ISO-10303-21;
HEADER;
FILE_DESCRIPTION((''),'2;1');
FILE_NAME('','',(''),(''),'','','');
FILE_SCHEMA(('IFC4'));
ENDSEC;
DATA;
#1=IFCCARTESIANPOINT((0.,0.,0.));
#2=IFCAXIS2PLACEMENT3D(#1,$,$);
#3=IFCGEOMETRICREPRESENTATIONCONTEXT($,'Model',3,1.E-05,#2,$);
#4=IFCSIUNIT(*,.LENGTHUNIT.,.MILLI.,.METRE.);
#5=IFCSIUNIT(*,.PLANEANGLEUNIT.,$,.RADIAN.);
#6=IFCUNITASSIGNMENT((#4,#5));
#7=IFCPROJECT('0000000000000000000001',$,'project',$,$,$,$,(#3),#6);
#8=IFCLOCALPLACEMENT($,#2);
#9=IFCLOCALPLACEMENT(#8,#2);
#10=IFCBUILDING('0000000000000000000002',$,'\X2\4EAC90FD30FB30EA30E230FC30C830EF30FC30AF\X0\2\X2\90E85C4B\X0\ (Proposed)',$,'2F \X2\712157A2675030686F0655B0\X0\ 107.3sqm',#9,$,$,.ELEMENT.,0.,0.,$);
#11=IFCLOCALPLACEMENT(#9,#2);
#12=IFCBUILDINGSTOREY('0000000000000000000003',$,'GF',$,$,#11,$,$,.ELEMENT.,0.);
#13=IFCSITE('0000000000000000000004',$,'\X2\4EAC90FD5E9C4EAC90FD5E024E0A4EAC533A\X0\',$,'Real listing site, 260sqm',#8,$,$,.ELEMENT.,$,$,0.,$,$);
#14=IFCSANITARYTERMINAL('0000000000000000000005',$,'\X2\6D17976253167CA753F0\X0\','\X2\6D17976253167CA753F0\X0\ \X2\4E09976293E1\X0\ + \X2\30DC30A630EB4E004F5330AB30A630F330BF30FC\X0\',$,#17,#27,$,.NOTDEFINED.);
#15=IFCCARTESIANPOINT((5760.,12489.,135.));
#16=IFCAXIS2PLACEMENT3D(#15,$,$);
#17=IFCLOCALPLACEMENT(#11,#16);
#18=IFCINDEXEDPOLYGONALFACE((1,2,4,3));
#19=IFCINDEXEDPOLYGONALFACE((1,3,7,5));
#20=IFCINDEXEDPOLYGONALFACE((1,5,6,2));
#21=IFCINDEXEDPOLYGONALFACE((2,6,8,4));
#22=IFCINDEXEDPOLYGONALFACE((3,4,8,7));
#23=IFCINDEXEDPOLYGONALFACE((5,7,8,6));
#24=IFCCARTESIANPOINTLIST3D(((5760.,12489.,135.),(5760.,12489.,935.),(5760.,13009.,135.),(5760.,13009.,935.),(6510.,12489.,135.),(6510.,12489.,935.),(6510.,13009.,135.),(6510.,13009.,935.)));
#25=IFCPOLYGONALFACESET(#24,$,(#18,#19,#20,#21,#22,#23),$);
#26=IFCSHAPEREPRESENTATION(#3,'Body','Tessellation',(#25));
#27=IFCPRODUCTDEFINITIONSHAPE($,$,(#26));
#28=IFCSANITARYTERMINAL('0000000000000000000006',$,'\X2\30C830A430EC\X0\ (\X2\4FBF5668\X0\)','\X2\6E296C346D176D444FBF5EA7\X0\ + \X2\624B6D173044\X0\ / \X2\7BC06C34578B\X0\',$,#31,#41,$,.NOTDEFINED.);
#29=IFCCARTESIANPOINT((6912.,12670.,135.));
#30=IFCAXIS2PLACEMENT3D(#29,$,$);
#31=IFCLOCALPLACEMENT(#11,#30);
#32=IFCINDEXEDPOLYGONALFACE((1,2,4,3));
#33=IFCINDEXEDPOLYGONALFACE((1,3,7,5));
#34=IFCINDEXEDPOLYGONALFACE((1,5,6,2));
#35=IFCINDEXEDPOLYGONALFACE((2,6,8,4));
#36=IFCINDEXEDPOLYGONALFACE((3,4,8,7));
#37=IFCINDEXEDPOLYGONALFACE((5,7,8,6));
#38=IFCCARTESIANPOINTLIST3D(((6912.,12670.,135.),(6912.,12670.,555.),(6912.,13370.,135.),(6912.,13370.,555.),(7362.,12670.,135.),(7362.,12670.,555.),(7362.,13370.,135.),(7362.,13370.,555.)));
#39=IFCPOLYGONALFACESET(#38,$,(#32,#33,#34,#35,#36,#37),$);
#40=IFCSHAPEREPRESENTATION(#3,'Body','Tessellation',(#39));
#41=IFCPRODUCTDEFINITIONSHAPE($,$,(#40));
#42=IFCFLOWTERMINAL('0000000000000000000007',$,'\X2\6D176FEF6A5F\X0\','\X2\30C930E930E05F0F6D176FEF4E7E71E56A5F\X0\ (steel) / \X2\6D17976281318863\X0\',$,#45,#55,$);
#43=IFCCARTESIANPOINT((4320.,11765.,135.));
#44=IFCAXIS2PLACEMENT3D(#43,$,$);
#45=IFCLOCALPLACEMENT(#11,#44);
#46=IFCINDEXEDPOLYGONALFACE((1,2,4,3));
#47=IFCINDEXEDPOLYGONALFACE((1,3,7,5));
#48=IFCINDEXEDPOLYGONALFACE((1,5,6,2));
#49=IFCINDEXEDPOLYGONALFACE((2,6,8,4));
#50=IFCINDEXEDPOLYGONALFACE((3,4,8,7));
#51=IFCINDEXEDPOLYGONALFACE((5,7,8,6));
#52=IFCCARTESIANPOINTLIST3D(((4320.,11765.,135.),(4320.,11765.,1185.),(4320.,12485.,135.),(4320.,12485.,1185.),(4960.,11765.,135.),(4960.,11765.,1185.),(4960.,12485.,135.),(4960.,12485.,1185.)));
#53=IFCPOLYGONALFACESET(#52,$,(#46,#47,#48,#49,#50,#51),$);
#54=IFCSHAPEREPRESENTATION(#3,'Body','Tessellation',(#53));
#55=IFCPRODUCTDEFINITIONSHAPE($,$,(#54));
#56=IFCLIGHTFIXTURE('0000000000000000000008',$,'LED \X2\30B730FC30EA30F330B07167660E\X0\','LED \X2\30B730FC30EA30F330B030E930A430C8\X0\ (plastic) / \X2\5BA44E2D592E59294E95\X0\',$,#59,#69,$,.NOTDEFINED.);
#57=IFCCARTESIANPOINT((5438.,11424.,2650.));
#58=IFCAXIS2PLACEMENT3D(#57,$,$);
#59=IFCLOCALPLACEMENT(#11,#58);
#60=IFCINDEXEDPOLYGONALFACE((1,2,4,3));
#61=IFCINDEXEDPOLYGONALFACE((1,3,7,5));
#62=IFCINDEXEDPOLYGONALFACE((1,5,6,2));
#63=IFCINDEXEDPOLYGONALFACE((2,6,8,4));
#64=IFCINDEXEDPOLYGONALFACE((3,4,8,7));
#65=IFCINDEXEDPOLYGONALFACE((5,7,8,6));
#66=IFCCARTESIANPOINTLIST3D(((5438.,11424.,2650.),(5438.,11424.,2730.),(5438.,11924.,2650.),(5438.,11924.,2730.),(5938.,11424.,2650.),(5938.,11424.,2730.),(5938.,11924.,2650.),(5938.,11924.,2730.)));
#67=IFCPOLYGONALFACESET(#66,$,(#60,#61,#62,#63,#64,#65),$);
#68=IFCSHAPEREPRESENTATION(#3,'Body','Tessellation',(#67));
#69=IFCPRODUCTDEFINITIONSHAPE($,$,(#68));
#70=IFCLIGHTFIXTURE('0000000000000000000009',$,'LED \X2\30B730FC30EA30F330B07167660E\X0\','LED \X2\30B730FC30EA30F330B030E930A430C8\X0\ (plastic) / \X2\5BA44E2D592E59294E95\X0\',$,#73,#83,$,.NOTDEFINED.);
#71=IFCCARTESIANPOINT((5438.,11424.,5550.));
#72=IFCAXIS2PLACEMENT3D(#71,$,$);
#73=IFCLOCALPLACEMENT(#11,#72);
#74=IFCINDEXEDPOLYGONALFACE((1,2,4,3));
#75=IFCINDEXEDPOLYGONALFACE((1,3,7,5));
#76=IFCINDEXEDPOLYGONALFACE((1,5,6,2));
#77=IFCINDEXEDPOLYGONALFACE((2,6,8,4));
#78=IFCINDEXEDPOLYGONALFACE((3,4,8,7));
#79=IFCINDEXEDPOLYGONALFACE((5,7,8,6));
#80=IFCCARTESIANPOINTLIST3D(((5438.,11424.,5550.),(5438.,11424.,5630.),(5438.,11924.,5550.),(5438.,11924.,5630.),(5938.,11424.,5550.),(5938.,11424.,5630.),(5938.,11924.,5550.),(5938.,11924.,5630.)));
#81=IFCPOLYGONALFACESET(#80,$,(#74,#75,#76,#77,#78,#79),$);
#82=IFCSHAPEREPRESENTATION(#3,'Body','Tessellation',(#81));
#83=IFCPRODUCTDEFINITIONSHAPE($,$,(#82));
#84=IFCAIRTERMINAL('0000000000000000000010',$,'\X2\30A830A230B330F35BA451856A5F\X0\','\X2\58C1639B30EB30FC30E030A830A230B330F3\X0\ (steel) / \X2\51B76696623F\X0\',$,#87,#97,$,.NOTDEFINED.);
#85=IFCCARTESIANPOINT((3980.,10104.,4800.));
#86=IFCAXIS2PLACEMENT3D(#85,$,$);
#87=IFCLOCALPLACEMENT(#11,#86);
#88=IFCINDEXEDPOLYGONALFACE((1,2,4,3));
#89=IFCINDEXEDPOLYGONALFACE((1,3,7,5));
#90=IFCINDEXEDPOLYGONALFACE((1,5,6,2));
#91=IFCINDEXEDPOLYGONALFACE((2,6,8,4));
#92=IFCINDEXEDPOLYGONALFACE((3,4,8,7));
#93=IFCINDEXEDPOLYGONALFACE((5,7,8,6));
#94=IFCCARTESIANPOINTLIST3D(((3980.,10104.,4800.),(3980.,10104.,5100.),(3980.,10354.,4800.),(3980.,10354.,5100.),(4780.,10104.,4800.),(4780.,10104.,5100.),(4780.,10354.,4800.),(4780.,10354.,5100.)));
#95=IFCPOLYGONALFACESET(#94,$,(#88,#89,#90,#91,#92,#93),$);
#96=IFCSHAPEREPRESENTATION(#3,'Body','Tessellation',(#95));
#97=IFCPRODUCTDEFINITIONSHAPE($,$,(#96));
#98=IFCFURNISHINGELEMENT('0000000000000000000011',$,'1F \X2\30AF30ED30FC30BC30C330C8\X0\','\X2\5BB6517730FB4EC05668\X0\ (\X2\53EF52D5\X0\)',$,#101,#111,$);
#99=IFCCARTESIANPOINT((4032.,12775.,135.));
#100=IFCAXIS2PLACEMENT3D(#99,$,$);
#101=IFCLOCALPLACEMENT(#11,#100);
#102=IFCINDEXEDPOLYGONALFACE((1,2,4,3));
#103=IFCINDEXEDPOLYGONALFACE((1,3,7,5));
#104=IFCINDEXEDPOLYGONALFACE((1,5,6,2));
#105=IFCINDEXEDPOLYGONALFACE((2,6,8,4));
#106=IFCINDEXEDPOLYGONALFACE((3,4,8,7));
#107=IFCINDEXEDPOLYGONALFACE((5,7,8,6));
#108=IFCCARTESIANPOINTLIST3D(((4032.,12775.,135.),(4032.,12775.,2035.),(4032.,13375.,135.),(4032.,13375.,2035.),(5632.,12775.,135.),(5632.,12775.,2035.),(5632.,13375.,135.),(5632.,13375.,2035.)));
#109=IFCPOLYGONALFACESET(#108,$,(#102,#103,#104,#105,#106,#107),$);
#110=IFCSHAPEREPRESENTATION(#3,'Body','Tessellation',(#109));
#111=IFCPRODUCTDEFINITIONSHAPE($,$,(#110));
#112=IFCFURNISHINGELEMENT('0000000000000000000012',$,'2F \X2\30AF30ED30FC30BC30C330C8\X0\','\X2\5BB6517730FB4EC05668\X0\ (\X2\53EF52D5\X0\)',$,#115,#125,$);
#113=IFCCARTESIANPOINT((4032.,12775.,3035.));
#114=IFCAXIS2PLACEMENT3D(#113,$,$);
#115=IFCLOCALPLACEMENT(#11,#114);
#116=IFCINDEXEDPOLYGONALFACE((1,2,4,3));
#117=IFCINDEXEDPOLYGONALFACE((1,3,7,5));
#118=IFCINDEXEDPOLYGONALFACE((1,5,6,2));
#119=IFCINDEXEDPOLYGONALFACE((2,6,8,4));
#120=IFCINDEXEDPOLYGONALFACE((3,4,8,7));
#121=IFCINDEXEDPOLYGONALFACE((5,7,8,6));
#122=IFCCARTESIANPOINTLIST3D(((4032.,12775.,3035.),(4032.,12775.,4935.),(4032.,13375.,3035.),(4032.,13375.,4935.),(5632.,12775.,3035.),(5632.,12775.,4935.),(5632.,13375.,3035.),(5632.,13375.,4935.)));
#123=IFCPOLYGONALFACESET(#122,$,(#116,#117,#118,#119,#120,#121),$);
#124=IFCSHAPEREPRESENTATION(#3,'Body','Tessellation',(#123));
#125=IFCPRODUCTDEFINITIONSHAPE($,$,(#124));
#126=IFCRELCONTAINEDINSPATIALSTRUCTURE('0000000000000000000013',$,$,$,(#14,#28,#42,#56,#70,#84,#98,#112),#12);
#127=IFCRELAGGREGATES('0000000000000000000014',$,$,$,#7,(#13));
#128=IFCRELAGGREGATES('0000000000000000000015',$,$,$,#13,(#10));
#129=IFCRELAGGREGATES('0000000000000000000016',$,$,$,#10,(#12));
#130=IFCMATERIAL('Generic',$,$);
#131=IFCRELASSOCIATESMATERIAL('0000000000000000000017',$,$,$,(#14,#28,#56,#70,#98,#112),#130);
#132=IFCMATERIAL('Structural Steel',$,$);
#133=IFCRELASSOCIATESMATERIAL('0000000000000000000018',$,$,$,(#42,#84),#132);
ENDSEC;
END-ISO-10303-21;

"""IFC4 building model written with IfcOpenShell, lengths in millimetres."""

from ifc_helpers import new_model, si_unit, frame, frame_2d, origin, place, context, project, spatial, rectangle, extrude, material, element, save


model = new_model("IFC4")

# Units and contexts
model_context = context("Model", 3, precision=1e-05, world=origin())
ifc_project = project(units=[si_unit("LENGTHUNIT", "METRE", prefix="MILLI"), si_unit("PLANEANGLEUNIT", "RADIAN")], contexts=[model_context])

# Site, building, storey
site_placement = place(None, origin())
site = spatial("IfcSite", under=ifc_project, at=site_placement, Name="京都府京都市上京区", ObjectType="Real listing site, 260sqm", CompositionType="ELEMENT", RefElevation=0.0)
building_placement = place(site_placement, origin())
building = spatial("IfcBuilding", under=site, at=building_placement, Name="京都・リモートワーク2部屋 (Proposed)", ObjectType="2F 無垢材と漆喰 107.3sqm", CompositionType="ELEMENT", ElevationOfRefHeight=0.0, ElevationOfTerrain=0.0)
storey_placement = place(building_placement, origin())
storey = spatial("IfcBuildingStorey", under=building, at=storey_placement, Name="GF", CompositionType="ELEMENT", Elevation=0.0)

# Sanitary terminals
ifc_material_1 = material(Name="Generic")
sanitary_terminal_1_placement = place(storey_placement, frame((5760.0, 12489.0, 135.0)))
element("IfcSanitaryTerminal", 1, at=sanitary_terminal_1_placement, inside=storey, material=ifc_material_1, Name="洗面化粧台", Description="洗面化粧台 三面鏡 + ボウル一体カウンター", PredefinedType="NOTDEFINED", context=model_context, shape_type="SweptSolid", body=[
    extrude(rectangle(XDim=750.0, YDim=520.0, at=frame_2d((375.0, 260.0))), frame((5760.0, 12489.0, 135.0)), (0.0, 0.0, 1.0), 800.0),
])
sanitary_terminal_2_placement = place(storey_placement, frame((6912.0, 12670.0, 135.0)))
element("IfcSanitaryTerminal", 2, at=sanitary_terminal_2_placement, inside=storey, material=ifc_material_1, Name="トイレ (便器)", Description="温水洗浄便座 + 手洗い / 節水型", PredefinedType="NOTDEFINED", context=model_context, shape_type="SweptSolid", body=[
    extrude(rectangle(XDim=450.0, YDim=700.0, at=frame_2d((225.0, 350.0))), frame((6912.0, 12670.0, 135.0)), (0.0, 0.0, 1.0), 420.0),
])

# Flow terminal
ifc_material_2 = material(Name="Structural Steel")
flow_terminal_placement = place(storey_placement, frame((4320.0, 11765.0, 135.0)))
element("IfcFlowTerminal", 3, at=flow_terminal_placement, inside=storey, material=ifc_material_2, Name="洗濯機", Description="ドラム式洗濯乾燥機 (steel) / 洗面脱衣", context=model_context, shape_type="SweptSolid", body=[
    extrude(rectangle(XDim=640.0, YDim=720.0, at=frame_2d((320.0, 360.0))), frame((4320.0, 11765.0, 135.0)), (0.0, 0.0, 1.0), 1050.0),
])

# Light fixtures
light_fixture_1_placement = place(storey_placement, frame((5438.0, 11424.0, 2650.0)))
element("IfcLightFixture", 4, at=light_fixture_1_placement, inside=storey, material=ifc_material_1, Name="LED シーリング照明", Description="LED シーリングライト (plastic) / 室中央天井", PredefinedType="NOTDEFINED", context=model_context, shape_type="SweptSolid", body=[
    extrude(rectangle(XDim=500.0, YDim=500.0, at=frame_2d((250.0, 250.0))), frame((5438.0, 11424.0, 2650.0)), (0.0, 0.0, 1.0), 80.0),
])
light_fixture_2_placement = place(storey_placement, frame((5438.0, 11424.0, 5550.0)))
element("IfcLightFixture", 5, at=light_fixture_2_placement, inside=storey, material=ifc_material_1, Name="LED シーリング照明", Description="LED シーリングライト (plastic) / 室中央天井", PredefinedType="NOTDEFINED", context=model_context, shape_type="SweptSolid", body=[
    extrude(rectangle(XDim=500.0, YDim=500.0, at=frame_2d((250.0, 250.0))), frame((5438.0, 11424.0, 5550.0)), (0.0, 0.0, 1.0), 80.0),
])

# Air terminal
air_terminal_placement = place(storey_placement, frame((3980.0, 10104.0, 4800.0)))
element("IfcAirTerminal", 6, at=air_terminal_placement, inside=storey, material=ifc_material_2, Name="エアコン室内機", Description="壁掛ルームエアコン (steel) / 冷暖房", PredefinedType="NOTDEFINED", context=model_context, shape_type="SweptSolid", body=[
    extrude(rectangle(XDim=800.0, YDim=250.0, at=frame_2d((400.0, 125.0))), frame((3980.0, 10104.0, 4800.0)), (0.0, 0.0, 1.0), 300.0),
])

# Furnishing elements
furnishing_1_placement = place(storey_placement, frame((4032.0, 12775.0, 135.0)))
element("IfcFurnishingElement", 7, at=furnishing_1_placement, inside=storey, material=ifc_material_1, Name="1F クローゼット", Description="家具・什器 (可動)", context=model_context, shape_type="SweptSolid", body=[
    extrude(rectangle(XDim=1600.0, YDim=600.0, at=frame_2d((800.0, 300.0))), frame((4032.0, 12775.0, 135.0)), (0.0, 0.0, 1.0), 1900.0),
])
furnishing_2_placement = place(storey_placement, frame((4032.0, 12775.0, 3035.0)))
element("IfcFurnishingElement", 8, at=furnishing_2_placement, inside=storey, material=ifc_material_1, Name="2F クローゼット", Description="家具・什器 (可動)", context=model_context, shape_type="SweptSolid", body=[
    extrude(rectangle(XDim=1600.0, YDim=600.0, at=frame_2d((800.0, 300.0))), frame((4032.0, 12775.0, 3035.0)), (0.0, 0.0, 1.0), 1900.0),
])

save(model, "model.ifc")
